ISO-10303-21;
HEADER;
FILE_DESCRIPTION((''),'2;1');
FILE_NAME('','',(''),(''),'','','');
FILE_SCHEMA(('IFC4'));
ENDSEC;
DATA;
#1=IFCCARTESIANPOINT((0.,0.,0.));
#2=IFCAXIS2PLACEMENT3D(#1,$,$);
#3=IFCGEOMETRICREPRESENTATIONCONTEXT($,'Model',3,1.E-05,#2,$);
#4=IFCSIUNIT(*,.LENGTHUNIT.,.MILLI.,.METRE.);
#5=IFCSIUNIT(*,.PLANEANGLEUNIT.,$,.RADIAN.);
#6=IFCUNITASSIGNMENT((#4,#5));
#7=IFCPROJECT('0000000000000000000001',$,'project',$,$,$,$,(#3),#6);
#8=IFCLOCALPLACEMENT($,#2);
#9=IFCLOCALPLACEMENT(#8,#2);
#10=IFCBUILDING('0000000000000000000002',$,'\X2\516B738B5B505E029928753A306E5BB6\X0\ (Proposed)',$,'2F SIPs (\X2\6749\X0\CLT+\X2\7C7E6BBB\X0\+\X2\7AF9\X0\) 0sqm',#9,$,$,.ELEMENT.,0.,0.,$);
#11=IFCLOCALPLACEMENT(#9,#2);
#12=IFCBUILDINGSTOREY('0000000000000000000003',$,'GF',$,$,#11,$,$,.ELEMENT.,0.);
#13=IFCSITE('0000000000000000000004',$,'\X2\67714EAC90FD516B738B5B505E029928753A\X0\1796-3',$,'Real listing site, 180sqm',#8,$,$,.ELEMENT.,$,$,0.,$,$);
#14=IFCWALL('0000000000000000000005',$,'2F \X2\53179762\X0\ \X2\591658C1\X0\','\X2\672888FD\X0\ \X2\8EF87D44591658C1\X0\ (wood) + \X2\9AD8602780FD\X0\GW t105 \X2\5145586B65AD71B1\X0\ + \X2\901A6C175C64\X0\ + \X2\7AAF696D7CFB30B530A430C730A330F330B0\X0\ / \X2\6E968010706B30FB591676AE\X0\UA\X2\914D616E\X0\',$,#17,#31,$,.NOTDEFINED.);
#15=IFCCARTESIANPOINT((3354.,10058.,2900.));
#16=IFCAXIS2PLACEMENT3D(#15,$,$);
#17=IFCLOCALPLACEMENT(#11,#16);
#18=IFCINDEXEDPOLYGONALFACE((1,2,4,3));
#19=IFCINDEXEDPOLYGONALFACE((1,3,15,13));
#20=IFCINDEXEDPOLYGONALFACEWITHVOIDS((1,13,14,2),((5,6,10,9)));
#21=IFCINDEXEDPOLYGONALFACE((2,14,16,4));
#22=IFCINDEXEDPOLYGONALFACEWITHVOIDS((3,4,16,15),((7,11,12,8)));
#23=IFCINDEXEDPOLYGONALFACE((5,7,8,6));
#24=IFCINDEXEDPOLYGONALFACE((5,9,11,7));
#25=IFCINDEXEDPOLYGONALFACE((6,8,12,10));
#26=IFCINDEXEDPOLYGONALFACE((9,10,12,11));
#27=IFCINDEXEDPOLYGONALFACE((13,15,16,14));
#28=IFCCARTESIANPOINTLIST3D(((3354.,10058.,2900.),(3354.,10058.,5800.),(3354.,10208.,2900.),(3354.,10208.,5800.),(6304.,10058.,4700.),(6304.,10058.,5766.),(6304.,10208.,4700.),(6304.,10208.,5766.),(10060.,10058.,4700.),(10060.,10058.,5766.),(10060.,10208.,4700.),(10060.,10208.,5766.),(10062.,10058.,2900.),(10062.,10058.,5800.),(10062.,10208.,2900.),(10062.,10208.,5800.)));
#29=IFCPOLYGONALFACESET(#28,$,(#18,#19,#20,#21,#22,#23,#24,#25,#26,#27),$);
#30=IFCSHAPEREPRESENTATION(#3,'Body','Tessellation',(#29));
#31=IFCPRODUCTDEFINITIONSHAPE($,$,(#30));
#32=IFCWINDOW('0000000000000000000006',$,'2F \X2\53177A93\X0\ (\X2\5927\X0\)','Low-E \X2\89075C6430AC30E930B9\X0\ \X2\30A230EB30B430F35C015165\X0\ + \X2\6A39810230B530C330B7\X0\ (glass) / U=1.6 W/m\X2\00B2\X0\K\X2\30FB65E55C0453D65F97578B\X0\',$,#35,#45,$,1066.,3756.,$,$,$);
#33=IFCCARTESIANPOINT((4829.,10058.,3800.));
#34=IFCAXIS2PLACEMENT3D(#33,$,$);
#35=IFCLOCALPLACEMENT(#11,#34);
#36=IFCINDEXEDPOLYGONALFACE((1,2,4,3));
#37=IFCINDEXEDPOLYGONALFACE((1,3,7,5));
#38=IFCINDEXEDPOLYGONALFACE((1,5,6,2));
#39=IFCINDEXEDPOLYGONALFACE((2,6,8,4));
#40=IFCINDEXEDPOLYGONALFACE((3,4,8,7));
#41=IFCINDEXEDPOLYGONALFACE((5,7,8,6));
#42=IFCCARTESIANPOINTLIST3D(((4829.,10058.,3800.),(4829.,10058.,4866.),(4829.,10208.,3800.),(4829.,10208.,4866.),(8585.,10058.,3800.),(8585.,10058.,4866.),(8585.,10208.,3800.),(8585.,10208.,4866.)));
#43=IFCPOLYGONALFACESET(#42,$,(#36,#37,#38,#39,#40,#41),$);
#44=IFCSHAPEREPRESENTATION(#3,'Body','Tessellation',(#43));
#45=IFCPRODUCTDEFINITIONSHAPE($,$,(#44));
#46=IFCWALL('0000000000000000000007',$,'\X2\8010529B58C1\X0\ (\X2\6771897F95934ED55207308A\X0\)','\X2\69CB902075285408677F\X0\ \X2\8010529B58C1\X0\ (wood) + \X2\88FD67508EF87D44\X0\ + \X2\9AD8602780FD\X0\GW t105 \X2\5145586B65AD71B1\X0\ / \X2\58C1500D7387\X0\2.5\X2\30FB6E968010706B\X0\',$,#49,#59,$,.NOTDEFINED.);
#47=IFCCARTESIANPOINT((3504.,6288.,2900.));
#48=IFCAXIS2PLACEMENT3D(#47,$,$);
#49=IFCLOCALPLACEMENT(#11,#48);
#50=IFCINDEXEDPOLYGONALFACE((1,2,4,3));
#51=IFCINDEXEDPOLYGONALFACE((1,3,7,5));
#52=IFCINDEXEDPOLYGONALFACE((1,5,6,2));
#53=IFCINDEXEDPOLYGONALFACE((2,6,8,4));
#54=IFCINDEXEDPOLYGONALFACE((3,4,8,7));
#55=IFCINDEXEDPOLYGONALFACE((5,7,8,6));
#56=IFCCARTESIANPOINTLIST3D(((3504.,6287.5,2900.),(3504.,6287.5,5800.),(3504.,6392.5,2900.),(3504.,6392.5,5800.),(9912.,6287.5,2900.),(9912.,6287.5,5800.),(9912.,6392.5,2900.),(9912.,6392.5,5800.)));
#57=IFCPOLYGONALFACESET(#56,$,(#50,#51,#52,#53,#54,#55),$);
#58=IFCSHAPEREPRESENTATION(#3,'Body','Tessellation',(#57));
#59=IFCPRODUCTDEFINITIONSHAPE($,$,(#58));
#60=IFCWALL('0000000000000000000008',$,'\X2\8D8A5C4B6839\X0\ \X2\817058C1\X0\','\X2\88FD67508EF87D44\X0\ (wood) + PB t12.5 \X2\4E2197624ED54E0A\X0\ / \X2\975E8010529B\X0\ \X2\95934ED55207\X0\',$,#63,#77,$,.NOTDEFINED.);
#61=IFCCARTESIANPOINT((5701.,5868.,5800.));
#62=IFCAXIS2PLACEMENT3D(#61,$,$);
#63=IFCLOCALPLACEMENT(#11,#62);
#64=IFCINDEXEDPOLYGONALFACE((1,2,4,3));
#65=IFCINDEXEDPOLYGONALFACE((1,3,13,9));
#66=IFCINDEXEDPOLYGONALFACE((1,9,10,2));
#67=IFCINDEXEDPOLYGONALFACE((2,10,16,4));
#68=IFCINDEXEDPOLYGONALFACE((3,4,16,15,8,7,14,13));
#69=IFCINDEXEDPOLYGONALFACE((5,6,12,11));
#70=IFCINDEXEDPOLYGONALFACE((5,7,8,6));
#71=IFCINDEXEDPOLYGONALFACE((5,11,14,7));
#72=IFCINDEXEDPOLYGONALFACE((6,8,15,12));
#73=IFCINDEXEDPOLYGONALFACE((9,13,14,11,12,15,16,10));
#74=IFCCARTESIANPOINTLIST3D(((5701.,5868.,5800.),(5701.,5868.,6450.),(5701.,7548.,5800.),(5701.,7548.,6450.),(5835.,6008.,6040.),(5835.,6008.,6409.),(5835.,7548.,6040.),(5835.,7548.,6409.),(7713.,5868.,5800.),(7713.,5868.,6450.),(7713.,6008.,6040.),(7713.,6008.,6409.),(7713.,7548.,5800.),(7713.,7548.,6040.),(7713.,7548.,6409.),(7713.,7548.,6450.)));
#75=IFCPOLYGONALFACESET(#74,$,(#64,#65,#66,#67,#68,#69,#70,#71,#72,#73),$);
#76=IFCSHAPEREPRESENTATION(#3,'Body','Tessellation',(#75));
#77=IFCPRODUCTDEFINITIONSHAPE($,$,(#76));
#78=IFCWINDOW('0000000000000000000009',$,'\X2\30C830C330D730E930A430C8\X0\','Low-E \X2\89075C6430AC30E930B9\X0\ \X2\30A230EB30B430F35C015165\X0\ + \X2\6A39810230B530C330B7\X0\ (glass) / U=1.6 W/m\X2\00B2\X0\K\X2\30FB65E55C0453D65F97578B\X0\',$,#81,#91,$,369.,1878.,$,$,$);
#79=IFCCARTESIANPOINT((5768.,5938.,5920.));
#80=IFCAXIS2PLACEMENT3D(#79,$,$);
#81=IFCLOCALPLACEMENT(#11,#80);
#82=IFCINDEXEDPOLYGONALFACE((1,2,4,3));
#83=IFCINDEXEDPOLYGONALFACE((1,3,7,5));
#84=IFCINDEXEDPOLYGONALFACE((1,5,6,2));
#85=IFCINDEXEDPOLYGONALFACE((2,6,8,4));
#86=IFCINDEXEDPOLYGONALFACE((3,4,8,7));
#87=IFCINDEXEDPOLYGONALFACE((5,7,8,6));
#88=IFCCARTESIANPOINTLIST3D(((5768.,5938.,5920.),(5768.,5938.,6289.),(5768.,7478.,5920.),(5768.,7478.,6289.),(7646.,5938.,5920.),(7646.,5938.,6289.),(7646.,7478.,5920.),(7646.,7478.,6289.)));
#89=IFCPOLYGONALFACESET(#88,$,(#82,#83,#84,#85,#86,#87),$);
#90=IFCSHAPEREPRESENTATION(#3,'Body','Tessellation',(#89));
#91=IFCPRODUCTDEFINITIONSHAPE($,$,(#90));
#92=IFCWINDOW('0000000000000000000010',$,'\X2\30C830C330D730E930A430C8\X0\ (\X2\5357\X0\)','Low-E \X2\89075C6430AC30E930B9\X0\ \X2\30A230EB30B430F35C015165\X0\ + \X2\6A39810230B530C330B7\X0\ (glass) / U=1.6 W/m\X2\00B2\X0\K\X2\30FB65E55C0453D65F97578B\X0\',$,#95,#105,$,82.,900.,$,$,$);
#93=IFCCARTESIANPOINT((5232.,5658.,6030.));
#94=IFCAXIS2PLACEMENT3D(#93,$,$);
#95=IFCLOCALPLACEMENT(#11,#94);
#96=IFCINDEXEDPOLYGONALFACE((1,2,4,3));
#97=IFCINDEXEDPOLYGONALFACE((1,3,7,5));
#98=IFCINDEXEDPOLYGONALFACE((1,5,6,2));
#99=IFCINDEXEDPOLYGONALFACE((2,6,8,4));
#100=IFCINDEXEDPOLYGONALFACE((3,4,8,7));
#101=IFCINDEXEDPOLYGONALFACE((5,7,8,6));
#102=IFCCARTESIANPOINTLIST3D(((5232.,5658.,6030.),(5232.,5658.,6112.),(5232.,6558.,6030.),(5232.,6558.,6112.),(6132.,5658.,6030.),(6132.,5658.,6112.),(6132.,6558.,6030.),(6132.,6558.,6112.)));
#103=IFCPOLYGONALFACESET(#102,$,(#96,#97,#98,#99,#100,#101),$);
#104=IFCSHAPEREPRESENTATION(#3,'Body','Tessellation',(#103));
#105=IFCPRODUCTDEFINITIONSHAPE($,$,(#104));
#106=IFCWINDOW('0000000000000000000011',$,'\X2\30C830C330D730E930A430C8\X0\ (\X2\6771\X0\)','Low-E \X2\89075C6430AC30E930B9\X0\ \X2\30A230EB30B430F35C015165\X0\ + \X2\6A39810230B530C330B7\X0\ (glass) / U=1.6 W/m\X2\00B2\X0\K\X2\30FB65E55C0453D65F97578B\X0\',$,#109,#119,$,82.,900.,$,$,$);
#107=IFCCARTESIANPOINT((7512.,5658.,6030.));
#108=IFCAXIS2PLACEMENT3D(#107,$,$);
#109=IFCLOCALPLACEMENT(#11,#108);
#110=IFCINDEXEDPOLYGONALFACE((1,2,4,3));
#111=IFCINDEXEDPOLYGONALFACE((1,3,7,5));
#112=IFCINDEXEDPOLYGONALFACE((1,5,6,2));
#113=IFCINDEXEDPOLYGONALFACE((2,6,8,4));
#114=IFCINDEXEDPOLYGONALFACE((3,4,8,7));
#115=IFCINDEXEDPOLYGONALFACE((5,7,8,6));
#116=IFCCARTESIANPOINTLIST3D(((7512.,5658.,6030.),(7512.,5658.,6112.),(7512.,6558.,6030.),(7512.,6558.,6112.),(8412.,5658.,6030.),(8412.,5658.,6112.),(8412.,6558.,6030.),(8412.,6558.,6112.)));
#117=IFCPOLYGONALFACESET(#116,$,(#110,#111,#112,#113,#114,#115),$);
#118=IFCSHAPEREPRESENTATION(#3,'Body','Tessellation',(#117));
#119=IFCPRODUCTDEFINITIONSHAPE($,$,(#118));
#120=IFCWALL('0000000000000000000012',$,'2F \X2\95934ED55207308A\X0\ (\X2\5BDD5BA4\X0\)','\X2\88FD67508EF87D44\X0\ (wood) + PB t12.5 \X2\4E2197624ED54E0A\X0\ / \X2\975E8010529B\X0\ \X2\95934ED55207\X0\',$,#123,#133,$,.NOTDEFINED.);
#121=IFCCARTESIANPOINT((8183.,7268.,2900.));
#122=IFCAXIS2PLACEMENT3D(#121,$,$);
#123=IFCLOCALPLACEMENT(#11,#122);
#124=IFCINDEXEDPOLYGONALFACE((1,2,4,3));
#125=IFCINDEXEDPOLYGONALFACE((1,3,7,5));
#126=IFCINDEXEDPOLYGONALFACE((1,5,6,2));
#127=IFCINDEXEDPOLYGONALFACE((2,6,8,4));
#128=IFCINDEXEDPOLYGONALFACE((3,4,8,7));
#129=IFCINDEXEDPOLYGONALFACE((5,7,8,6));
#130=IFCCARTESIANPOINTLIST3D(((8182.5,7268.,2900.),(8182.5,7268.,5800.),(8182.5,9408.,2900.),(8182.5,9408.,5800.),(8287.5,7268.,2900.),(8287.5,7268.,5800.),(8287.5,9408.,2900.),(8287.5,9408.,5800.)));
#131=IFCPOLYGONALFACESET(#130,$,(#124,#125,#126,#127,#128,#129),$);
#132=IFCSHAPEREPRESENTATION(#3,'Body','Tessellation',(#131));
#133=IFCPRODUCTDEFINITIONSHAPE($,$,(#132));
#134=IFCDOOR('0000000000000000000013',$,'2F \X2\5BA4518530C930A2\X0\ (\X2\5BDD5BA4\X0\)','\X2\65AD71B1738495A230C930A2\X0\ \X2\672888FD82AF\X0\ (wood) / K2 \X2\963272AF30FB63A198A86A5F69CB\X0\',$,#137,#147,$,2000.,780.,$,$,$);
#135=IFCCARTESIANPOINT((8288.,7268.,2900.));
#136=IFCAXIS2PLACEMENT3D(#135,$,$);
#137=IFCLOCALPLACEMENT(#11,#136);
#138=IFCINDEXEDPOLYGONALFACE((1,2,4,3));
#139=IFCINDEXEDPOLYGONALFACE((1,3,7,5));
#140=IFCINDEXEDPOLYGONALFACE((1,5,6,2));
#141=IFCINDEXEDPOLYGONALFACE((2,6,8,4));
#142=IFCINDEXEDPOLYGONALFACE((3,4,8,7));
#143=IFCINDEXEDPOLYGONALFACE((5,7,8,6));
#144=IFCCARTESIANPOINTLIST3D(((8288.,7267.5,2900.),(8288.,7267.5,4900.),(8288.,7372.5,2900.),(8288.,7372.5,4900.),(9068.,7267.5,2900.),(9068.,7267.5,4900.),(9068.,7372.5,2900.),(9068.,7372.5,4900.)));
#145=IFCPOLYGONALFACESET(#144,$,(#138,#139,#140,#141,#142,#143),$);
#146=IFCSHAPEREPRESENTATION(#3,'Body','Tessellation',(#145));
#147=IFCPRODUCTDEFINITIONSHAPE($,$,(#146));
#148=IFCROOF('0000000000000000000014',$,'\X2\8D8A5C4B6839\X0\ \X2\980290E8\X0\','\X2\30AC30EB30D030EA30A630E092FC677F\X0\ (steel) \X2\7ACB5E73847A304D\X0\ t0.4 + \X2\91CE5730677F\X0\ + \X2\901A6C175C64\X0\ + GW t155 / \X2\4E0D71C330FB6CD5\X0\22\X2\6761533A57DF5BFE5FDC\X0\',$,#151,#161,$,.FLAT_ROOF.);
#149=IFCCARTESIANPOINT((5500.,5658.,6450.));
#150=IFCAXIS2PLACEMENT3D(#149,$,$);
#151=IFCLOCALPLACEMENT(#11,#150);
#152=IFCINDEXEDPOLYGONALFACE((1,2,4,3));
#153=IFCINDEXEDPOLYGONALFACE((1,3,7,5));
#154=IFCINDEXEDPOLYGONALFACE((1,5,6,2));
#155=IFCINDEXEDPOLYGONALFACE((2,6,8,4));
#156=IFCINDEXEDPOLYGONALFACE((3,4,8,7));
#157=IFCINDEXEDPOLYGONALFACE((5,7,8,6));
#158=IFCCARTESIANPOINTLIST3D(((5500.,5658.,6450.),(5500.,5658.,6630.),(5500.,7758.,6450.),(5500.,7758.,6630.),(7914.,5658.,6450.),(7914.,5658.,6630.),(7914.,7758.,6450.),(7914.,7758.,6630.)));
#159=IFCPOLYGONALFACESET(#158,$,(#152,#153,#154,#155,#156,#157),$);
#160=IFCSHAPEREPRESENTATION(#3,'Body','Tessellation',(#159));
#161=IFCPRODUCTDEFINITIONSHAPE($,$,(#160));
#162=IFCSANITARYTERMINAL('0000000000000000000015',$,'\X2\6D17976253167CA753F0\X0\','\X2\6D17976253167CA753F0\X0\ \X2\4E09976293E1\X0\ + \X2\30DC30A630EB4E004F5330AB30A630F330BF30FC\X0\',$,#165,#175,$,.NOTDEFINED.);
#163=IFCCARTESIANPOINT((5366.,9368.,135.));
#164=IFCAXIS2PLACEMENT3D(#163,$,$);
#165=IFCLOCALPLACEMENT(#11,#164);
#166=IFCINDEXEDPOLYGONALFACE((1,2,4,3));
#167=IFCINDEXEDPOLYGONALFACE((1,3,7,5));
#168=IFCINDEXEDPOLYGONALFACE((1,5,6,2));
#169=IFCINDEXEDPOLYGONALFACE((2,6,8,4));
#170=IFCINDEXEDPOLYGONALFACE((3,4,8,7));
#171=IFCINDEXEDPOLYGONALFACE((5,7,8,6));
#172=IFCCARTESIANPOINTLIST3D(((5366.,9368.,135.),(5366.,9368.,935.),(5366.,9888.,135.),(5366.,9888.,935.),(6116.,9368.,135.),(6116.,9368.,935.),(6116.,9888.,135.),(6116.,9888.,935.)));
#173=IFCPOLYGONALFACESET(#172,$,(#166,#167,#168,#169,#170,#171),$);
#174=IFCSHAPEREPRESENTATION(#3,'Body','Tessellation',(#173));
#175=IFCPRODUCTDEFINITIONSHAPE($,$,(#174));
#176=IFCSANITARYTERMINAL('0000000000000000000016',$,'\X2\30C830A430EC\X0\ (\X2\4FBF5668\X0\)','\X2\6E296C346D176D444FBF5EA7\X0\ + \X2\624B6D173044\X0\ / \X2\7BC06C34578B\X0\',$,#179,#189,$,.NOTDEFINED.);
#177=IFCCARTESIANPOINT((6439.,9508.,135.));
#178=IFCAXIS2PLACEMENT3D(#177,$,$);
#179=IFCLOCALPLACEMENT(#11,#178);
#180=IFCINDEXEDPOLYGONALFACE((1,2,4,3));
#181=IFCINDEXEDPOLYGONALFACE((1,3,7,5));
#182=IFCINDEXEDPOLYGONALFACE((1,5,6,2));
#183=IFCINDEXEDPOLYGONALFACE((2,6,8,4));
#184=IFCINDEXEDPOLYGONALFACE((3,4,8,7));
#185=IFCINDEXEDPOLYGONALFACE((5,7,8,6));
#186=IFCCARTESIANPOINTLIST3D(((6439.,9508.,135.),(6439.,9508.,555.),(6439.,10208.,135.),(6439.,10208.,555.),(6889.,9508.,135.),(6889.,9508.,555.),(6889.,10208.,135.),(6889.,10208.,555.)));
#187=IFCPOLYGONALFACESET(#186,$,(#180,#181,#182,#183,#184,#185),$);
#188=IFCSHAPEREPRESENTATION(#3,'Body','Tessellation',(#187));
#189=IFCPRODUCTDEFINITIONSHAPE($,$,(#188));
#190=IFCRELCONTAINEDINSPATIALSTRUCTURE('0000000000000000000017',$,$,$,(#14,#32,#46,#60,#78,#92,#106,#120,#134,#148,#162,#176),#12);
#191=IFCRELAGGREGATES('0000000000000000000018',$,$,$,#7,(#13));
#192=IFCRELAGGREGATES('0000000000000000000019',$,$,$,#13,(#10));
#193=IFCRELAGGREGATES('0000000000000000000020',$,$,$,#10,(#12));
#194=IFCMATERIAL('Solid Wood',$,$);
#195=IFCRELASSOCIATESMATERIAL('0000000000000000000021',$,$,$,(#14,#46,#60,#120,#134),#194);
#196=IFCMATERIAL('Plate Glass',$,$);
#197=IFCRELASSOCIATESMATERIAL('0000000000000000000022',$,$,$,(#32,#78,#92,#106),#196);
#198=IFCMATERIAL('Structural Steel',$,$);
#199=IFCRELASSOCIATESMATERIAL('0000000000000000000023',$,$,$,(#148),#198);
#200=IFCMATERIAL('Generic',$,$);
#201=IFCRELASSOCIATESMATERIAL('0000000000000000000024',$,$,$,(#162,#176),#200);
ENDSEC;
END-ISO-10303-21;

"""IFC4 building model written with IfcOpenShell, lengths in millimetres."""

from ifc_helpers import new_model, si_unit, frame, frame_2d, origin, place, context, project, spatial, rectangle, extrude, material, element, fill, save


model = new_model("IFC4")

# Units and contexts
model_context = context("Model", 3, precision=1e-05, world=origin())
ifc_project = project(units=[si_unit("LENGTHUNIT", "METRE", prefix="MILLI"), si_unit("PLANEANGLEUNIT", "RADIAN")], contexts=[model_context])

# Site, building, storey
site_placement = place(None, origin())
site = spatial("IfcSite", under=ifc_project, at=site_placement, Name="東京都八王子市館町1796-3", ObjectType="Real listing site, 180sqm", CompositionType="ELEMENT", RefElevation=0.0)
building_placement = place(site_placement, origin())
building = spatial("IfcBuilding", under=site, at=building_placement, Name="八王子市館町の家 (Proposed)", ObjectType="2F SIPs (杉CLT+籾殻+竹) 0sqm", CompositionType="ELEMENT", ElevationOfRefHeight=0.0, ElevationOfTerrain=0.0)
storey_placement = place(building_placement, origin())
storey = spatial("IfcBuildingStorey", under=building, at=storey_placement, Name="GF", CompositionType="ELEMENT", Elevation=0.0)

# Wall, opening, window
ifc_material_1 = material(Name="Solid Wood")
wall_1_placement = place(storey_placement, frame((3354.0, 10058.0, 2900.0)))
wall_1 = element("IfcWall", 1, at=wall_1_placement, inside=storey, material=ifc_material_1, Name="2F 北面 外壁", Description="木製 軸組外壁 (wood) + 高性能GW t105 充填断熱 + 通気層 + 窯業系サイディング / 準耐火・外皮UA配慮", PredefinedType="NOTDEFINED", context=model_context, shape_type="SweptSolid", body=[
    extrude(rectangle(XDim=6708.0, YDim=150.0, at=frame_2d((3354.0, 75.0))), frame((3354.0, 10058.0, 2900.0)), (0.0, 0.0, 1.0), 2900.0),
])
opening_1_placement = place(storey_placement, frame((4829.0, 10058.0, 3800.0)))
opening_1 = element("IfcOpeningElement", 2, at=opening_1_placement, cuts=wall_1, PredefinedType="NOTDEFINED", context=model_context, shape_type="SweptSolid", body=[
    extrude(rectangle(XDim=3756.0, YDim=150.0, at=frame_2d((1878.0, 75.0))), frame((4829.0, 10058.0, 3800.0)), (0.0, 0.0, 1.0), 1066.0),
])
ifc_material_2 = material(Name="Plate Glass")
window_1_placement = place(storey_placement, frame((4829.0, 10058.0, 3800.0)))
window_1 = element("IfcWindow", 3, at=window_1_placement, inside=storey, material=ifc_material_2, Name="2F 北窓 (大)", Description="Low-E 複層ガラス アルゴン封入 + 樹脂サッシ (glass) / U=1.6 W/m²K・日射取得型", OverallHeight=1066.0, OverallWidth=3756.0, context=model_context, shape_type="SweptSolid", body=[
    extrude(rectangle(XDim=3756.0, YDim=150.0, at=frame_2d((1878.0, 75.0))), frame((4829.0, 10058.0, 3800.0)), (0.0, 0.0, 1.0), 1066.0),
])
fill(opening_1, window_1)

# Wall
wall_2_placement = place(storey_placement, frame((3504.0, 6288.0, 2900.0)))
element("IfcWall", 4, at=wall_2_placement, inside=storey, material=ifc_material_1, Name="耐力壁 (東西間仕切り)", Description="構造用合板 耐力壁 (wood) + 製材軸組 + 高性能GW t105 充填断熱 / 壁倍率2.5・準耐火", PredefinedType="NOTDEFINED", context=model_context, shape_type="SweptSolid", body=[
    extrude(rectangle(XDim=6408.0, YDim=105.0, at=frame_2d((3204.0, 52.0))), frame((3504.0, 6288.0, 2900.0)), (0.0, 0.0, 1.0), 2900.0),
])

# Wall, openings, windows
wall_3_placement = place(storey_placement, frame((5701.0, 5868.0, 5800.0)))
wall_3 = element("IfcWall", 5, at=wall_3_placement, inside=storey, material=ifc_material_1, Name="越屋根 腰壁", Description="製材軸組 (wood) + PB t12.5 両面仕上 / 非耐力 間仕切", PredefinedType="NOTDEFINED", context=model_context, shape_type="SweptSolid", body=[
    extrude(rectangle(XDim=2012.0, YDim=1680.0, at=frame_2d((1006.0, 840.0))), frame((5701.0, 5868.0, 5800.0)), (0.0, 0.0, 1.0), 650.0),
])
opening_2_placement = place(storey_placement, frame((5768.0, 5938.0, 5920.0)))
opening_2 = element("IfcOpeningElement", 6, at=opening_2_placement, cuts=wall_3, PredefinedType="NOTDEFINED", context=model_context, shape_type="SweptSolid", body=[
    extrude(rectangle(XDim=1878.0, YDim=1540.0, at=frame_2d((939.0, 770.0))), frame((5768.0, 5938.0, 5920.0)), (0.0, 0.0, 1.0), 369.0),
])
opening_3_placement = place(storey_placement, frame((5232.0, 5658.0, 6030.0)))
opening_3 = element("IfcOpeningElement", 7, at=opening_3_placement, cuts=wall_3, PredefinedType="NOTDEFINED", context=model_context, shape_type="SweptSolid", body=[
    extrude(rectangle(XDim=900.0, YDim=900.0, at=frame_2d((450.0, 450.0))), frame((5232.0, 5658.0, 6030.0)), (0.0, 0.0, 1.0), 82.0),
])
opening_4_placement = place(storey_placement, frame((7512.0, 5658.0, 6030.0)))
opening_4 = element("IfcOpeningElement", 8, at=opening_4_placement, cuts=wall_3, PredefinedType="NOTDEFINED", context=model_context, shape_type="SweptSolid", body=[
    extrude(rectangle(XDim=900.0, YDim=900.0, at=frame_2d((450.0, 450.0))), frame((7512.0, 5658.0, 6030.0)), (0.0, 0.0, 1.0), 82.0),
])
window_2_placement = place(storey_placement, frame((5768.0, 5938.0, 5920.0)))
window_2 = element("IfcWindow", 9, at=window_2_placement, inside=storey, material=ifc_material_2, Name="トップライト", Description="Low-E 複層ガラス アルゴン封入 + 樹脂サッシ (glass) / U=1.6 W/m²K・日射取得型", OverallHeight=369.0, OverallWidth=1878.0, context=model_context, shape_type="SweptSolid", body=[
    extrude(rectangle(XDim=1878.0, YDim=1540.0, at=frame_2d((939.0, 770.0))), frame((5768.0, 5938.0, 5920.0)), (0.0, 0.0, 1.0), 369.0),
])
fill(opening_2, window_2)
window_3_placement = place(storey_placement, frame((5232.0, 5658.0, 6030.0)))
window_3 = element("IfcWindow", 10, at=window_3_placement, inside=storey, material=ifc_material_2, Name="トップライト (南)", Description="Low-E 複層ガラス アルゴン封入 + 樹脂サッシ (glass) / U=1.6 W/m²K・日射取得型", OverallHeight=82.0, OverallWidth=900.0, context=model_context, shape_type="SweptSolid", body=[
    extrude(rectangle(XDim=900.0, YDim=900.0, at=frame_2d((450.0, 450.0))), frame((5232.0, 5658.0, 6030.0)), (0.0, 0.0, 1.0), 82.0),
])
fill(opening_3, window_3)
window_4_placement = place(storey_placement, frame((7512.0, 5658.0, 6030.0)))
window_4 = element("IfcWindow", 11, at=window_4_placement, inside=storey, material=ifc_material_2, Name="トップライト (東)", Description="Low-E 複層ガラス アルゴン封入 + 樹脂サッシ (glass) / U=1.6 W/m²K・日射取得型", OverallHeight=82.0, OverallWidth=900.0, context=model_context, shape_type="SweptSolid", body=[
    extrude(rectangle(XDim=900.0, YDim=900.0, at=frame_2d((450.0, 450.0))), frame((7512.0, 5658.0, 6030.0)), (0.0, 0.0, 1.0), 82.0),
])
fill(opening_4, window_4)

# Wall
wall_4_placement = place(storey_placement, frame((8183.0, 7268.0, 2900.0)))
element("IfcWall", 12, at=wall_4_placement, inside=storey, material=ifc_material_1, Name="2F 間仕切り (寝室)", Description="製材軸組 (wood) + PB t12.5 両面仕上 / 非耐力 間仕切", PredefinedType="NOTDEFINED", context=model_context, shape_type="SweptSolid", body=[
    extrude(rectangle(XDim=105.0, YDim=2140.0, at=frame_2d((52.0, 1070.0))), frame((8183.0, 7268.0, 2900.0)), (0.0, 0.0, 1.0), 2900.0),
])

# Door
door_placement = place(storey_placement, frame((8288.0, 7268.0, 2900.0)))
element("IfcDoor", 13, at=door_placement, inside=storey, material=ifc_material_1, Name="2F 室内ドア (寝室)", Description="断熱玄関ドア 木製芯 (wood) / K2 防犯・採風機構", OverallHeight=2000.0, OverallWidth=780.0, context=model_context, shape_type="SweptSolid", body=[
    extrude(rectangle(XDim=780.0, YDim=105.0, at=frame_2d((390.0, 52.0))), frame((8288.0, 7268.0, 2900.0)), (0.0, 0.0, 1.0), 2000.0),
])

# Roof
ifc_material_3 = material(Name="Structural Steel")
roof_placement = place(storey_placement, frame((5500.0, 5658.0, 6450.0)))
element("IfcRoof", 14, at=roof_placement, inside=storey, material=ifc_material_3, Name="越屋根 頂部", Description="ガルバリウム鋼板 (steel) 立平葺き t0.4 + 野地板 + 通気層 + GW t155 / 不燃・法22条区域対応", PredefinedType="FLAT_ROOF", context=model_context, shape_type="SweptSolid", body=[
    extrude(rectangle(XDim=2414.0, YDim=2100.0, at=frame_2d((1207.0, 1050.0))), frame((5500.0, 5658.0, 6450.0)), (0.0, 0.0, 1.0), 180.0),
])

# Sanitary terminals
ifc_material_4 = material(Name="Generic")
sanitary_terminal_1_placement = place(storey_placement, frame((5366.0, 9368.0, 135.0)))
element("IfcSanitaryTerminal", 15, at=sanitary_terminal_1_placement, inside=storey, material=ifc_material_4, Name="洗面化粧台", Description="洗面化粧台 三面鏡 + ボウル一体カウンター", PredefinedType="NOTDEFINED", context=model_context, shape_type="SweptSolid", body=[
    extrude(rectangle(XDim=750.0, YDim=520.0, at=frame_2d((375.0, 260.0))), frame((5366.0, 9368.0, 135.0)), (0.0, 0.0, 1.0), 800.0),
])
sanitary_terminal_2_placement = place(storey_placement, frame((6439.0, 9508.0, 135.0)))
element("IfcSanitaryTerminal", 16, at=sanitary_terminal_2_placement, inside=storey, material=ifc_material_4, Name="トイレ (便器)", Description="温水洗浄便座 + 手洗い / 節水型", PredefinedType="NOTDEFINED", context=model_context, shape_type="SweptSolid", body=[
    extrude(rectangle(XDim=450.0, YDim=700.0, at=frame_2d((225.0, 350.0))), frame((6439.0, 9508.0, 135.0)), (0.0, 0.0, 1.0), 420.0),
])

save(model, "model.ifc")
